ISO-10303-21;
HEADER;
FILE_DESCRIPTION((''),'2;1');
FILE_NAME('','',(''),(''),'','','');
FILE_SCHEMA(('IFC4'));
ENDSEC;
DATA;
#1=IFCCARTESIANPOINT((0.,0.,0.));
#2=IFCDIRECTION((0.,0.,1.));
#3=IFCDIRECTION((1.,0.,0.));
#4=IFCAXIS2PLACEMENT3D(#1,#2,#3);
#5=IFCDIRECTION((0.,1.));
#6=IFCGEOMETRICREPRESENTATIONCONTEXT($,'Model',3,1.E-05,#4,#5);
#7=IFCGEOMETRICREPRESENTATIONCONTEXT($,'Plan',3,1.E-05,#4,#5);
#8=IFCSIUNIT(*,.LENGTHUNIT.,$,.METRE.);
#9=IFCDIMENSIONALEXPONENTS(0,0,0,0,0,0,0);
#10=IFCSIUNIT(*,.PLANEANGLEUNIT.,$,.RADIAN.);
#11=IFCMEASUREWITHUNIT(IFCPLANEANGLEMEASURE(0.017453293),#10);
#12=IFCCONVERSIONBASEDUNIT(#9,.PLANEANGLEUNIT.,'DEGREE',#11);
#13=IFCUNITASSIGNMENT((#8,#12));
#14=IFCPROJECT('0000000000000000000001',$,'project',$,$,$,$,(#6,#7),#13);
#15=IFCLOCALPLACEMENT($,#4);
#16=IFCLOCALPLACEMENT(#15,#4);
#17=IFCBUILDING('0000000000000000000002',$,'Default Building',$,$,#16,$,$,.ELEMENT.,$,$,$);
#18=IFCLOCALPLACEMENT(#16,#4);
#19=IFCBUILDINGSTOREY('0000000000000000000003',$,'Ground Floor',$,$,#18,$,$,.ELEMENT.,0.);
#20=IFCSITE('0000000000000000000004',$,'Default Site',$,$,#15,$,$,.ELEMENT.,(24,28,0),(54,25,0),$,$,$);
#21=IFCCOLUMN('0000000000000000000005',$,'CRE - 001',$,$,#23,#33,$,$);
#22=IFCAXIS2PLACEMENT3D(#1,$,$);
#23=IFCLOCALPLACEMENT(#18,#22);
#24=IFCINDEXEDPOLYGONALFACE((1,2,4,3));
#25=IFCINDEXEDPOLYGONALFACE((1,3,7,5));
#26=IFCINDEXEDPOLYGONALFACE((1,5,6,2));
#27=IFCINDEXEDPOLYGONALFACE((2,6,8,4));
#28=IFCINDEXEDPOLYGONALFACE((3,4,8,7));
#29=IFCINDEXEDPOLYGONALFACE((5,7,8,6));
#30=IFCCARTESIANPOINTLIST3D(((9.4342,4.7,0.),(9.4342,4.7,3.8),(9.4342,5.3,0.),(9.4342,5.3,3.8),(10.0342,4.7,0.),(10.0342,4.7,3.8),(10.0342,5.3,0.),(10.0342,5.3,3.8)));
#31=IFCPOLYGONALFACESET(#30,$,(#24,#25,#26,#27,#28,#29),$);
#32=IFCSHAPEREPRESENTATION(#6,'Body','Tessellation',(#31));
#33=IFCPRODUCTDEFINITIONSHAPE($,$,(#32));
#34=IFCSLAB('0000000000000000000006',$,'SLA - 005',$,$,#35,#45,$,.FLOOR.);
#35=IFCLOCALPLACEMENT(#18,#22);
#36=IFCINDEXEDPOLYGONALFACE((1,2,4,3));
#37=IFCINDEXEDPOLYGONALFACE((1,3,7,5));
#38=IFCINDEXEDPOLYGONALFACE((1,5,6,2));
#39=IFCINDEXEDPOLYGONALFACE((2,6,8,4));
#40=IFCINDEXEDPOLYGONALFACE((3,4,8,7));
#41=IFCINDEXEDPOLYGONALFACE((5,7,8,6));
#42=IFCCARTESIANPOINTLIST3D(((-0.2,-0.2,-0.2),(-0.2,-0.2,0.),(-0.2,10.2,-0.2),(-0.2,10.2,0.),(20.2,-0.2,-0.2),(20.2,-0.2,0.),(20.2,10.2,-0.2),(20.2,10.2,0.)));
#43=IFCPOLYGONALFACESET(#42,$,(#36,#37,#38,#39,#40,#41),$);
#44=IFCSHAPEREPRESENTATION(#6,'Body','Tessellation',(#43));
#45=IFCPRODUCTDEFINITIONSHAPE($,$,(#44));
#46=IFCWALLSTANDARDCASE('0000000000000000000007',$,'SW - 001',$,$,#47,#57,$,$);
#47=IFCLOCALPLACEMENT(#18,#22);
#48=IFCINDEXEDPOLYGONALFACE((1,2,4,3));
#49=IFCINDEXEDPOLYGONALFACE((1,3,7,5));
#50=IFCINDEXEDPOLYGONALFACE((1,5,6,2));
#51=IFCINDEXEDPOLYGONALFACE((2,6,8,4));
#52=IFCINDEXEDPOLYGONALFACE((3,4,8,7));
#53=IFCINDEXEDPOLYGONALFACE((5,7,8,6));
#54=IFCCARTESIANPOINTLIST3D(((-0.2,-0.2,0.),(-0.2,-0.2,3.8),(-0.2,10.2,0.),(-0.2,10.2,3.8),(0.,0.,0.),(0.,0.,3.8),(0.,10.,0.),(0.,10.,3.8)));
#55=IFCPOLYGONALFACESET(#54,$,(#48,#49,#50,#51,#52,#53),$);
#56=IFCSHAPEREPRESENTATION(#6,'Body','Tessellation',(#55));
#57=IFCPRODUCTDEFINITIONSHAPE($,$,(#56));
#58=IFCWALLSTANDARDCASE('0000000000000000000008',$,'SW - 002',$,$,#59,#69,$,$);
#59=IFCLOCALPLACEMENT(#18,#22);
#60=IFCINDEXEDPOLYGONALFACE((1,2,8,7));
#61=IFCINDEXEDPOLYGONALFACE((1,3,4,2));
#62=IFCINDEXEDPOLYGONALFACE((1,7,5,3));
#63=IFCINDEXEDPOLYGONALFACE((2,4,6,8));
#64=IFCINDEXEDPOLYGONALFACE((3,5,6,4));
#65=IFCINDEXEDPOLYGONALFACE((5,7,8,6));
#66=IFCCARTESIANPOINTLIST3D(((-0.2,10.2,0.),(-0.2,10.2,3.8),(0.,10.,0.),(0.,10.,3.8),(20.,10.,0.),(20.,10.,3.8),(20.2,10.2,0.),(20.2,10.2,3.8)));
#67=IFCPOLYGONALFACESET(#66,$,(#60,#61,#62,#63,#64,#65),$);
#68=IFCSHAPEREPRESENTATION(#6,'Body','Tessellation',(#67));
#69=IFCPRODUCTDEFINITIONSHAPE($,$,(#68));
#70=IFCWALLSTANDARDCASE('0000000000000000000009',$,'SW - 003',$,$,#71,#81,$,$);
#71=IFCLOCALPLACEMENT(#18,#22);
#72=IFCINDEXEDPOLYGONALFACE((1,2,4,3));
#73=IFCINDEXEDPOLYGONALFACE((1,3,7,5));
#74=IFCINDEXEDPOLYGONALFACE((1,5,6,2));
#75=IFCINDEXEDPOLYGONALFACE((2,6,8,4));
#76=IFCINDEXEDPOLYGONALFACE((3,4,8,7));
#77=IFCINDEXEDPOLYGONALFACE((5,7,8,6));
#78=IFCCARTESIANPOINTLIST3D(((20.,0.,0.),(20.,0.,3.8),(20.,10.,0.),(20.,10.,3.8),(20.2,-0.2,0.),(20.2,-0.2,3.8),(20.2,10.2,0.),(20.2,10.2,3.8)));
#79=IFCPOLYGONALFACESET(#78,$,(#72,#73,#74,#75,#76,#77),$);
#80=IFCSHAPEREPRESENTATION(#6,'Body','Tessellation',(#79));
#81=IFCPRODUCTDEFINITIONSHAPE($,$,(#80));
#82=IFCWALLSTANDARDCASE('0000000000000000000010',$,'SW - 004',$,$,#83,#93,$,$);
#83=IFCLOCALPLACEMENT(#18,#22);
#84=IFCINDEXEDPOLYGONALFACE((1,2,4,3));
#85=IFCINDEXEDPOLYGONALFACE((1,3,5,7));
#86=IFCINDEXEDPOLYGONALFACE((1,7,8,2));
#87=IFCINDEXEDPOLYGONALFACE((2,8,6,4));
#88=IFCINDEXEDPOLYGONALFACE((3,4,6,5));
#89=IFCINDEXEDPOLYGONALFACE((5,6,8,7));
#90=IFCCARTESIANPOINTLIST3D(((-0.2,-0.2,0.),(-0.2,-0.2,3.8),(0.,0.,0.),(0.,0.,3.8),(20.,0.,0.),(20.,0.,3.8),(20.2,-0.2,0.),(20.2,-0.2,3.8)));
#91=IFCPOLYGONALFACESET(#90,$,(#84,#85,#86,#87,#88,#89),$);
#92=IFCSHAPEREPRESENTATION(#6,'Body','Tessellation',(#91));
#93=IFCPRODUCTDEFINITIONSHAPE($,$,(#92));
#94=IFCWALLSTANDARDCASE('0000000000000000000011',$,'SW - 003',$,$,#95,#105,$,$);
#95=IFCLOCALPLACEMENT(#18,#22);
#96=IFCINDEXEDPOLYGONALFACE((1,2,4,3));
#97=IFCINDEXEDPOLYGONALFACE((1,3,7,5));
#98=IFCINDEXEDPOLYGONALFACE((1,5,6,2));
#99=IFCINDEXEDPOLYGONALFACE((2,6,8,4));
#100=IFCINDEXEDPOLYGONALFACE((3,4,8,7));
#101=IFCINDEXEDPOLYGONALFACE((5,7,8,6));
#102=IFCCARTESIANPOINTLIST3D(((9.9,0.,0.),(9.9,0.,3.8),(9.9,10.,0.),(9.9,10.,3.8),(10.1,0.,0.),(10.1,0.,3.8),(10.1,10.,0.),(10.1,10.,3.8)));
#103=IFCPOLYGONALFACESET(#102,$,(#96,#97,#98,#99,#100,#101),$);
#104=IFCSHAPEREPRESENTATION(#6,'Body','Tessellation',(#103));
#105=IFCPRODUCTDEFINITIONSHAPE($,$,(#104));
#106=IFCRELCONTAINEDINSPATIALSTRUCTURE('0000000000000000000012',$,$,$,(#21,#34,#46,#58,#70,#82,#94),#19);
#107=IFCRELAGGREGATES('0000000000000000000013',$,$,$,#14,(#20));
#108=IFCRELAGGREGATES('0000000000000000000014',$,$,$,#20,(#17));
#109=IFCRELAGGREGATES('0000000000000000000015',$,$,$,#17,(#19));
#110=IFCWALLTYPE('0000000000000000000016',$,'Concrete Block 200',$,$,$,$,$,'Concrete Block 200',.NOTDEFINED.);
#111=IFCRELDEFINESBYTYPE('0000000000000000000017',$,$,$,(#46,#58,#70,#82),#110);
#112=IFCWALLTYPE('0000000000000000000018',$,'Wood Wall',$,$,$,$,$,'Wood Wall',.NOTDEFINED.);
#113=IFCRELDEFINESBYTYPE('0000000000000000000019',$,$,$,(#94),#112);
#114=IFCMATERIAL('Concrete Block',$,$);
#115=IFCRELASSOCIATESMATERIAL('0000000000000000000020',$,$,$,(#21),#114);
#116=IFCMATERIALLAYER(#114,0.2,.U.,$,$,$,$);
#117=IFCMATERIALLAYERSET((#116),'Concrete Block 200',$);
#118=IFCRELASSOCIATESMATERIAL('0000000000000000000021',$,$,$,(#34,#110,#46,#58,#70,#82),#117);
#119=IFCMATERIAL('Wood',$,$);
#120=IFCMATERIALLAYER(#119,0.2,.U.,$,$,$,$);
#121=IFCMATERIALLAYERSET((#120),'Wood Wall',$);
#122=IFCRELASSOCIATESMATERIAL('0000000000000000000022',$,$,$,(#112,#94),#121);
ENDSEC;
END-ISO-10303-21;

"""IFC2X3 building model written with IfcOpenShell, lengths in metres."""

from ifc_helpers import new_model, entity, si_unit, converted_unit, direction, frame, origin_with_axes, origin_2d_with_axis, place, context, project, spatial, polyline, rectangle, outline, extrude, material, layer, layer_set, layer_usage, type_object, element, save


model = new_model("IFC2X3")

# Units and contexts
model_context = context("Model", 3, precision=1e-05, world=origin_with_axes(), true_north=direction((0.0, 1.0)))
plan_context = context("Plan", 3, precision=1e-05, world=origin_with_axes(), true_north=direction((0.0, 1.0)))
ifc_project = project(units=[si_unit("LENGTHUNIT", "METRE"), converted_unit("PLANEANGLEUNIT", "DEGREE", entity("IfcPlaneAngleMeasure", 0.017453293), si_unit("PLANEANGLEUNIT", "RADIAN"), dimensions=[0, 0, 0, 0, 0, 0, 0])], contexts=[model_context, plan_context])

# Site, building, storey
site_placement = place(None, origin_with_axes())
site = spatial("IfcSite", under=ifc_project, at=site_placement, Name="Default Site", CompositionType="ELEMENT", RefLatitude=(24, 28, 0), RefLongitude=(54, 25, 0))
building_placement = place(site_placement, origin_with_axes())
building = spatial("IfcBuilding", under=site, at=building_placement, Name="Default Building", CompositionType="ELEMENT")
storey_placement = place(building_placement, origin_with_axes())
storey = spatial("IfcBuildingStorey", under=building, at=storey_placement, Name="Ground Floor", CompositionType="ELEMENT", Elevation=0.0)

# Column
ifc_material_1 = material(Name="Concrete Block")
column_placement = place(storey_placement, frame((9.7342, 5.0, 0.0), z_axis=(0.0, 0.0, 1.0), x_axis=(1.0, 0.0, 0.0)))
element("IfcColumn", 1, at=column_placement, inside=storey, material=ifc_material_1, Name="CRE - 001", context=model_context, shape_type="SweptSolid", body=[
    extrude(rectangle(XDim=0.6, YDim=0.6, at=origin_2d_with_axis()), origin_with_axes(), (0.0, 0.0, 1.0), 3.8),
])

# Slab
ifc_layer_1 = layer(ifc_material_1, 0.2, ventilated="UNKNOWN")
ifc_layer_set_1 = layer_set([ifc_layer_1], Name="Concrete Block 200")
ifc_layer_usage_1 = layer_usage(ifc_layer_set_1, "AXIS3", "NEGATIVE", 0.2)
slab_placement = place(storey_placement, frame((-0.2, 10.2, -0.2), z_axis=(0.0, 0.0, 1.0), x_axis=(1.0, 0.0, 0.0)))
element("IfcSlab", 2, at=slab_placement, inside=storey, material=ifc_layer_usage_1, Name="SLA - 005", PredefinedType="FLOOR", context=model_context, shape_type="SweptSolid", body=[
    extrude(outline(polyline([(0.0, 0.0), (20.4, 0.0), (20.4, -10.4), (0.0, -10.4), (0.0, 0.0)])), origin_with_axes(), (0.0, 0.0, 1.0), 0.2),
])

# Walls
ifc_layer_usage_2 = layer_usage(ifc_layer_set_1, "AXIS2", "POSITIVE", 0.0)
wall_type_1 = type_object("IfcWallType", Name="Concrete Block 200", ElementType="Concrete Block 200", PredefinedType="NOTDEFINED", material=ifc_layer_set_1)
wall_1_placement = place(storey_placement, frame((0.0, 0.0, 0.0), z_axis=(0.0, 0.0, 1.0), x_axis=(0.0, 1.0, 0.0)))
element("IfcWallStandardCase", 3, at=wall_1_placement, inside=storey, type_object=wall_type_1, material=ifc_layer_usage_2, Name="SW - 001", context=model_context, shape_type="SweptSolid", body=[
    extrude(outline(polyline([(0.0, 0.0), (10.0, 0.0), (10.2, 0.2), (-0.2, 0.2), (0.0, 0.0)])), origin_with_axes(), (0.0, 0.0, 1.0), 3.8),
])
ifc_layer_usage_3 = layer_usage(ifc_layer_set_1, "AXIS2", "POSITIVE", 0.0)
wall_2_placement = place(storey_placement, frame((0.0, 10.0, 0.0), z_axis=(0.0, 0.0, 1.0), x_axis=(1.0, 0.0, 0.0)))
element("IfcWallStandardCase", 4, at=wall_2_placement, inside=storey, type_object=wall_type_1, material=ifc_layer_usage_3, Name="SW - 002", context=model_context, shape_type="SweptSolid", body=[
    extrude(outline(polyline([(0.0, 0.0), (20.0, 0.0), (20.2, 0.2), (-0.2, 0.2), (0.0, 0.0)])), origin_with_axes(), (0.0, 0.0, 1.0), 3.8),
])
ifc_layer_usage_4 = layer_usage(ifc_layer_set_1, "AXIS2", "POSITIVE", 0.0)
wall_3_placement = place(storey_placement, frame((20.0, 10.0, 0.0), z_axis=(0.0, 0.0, 1.0), x_axis=(0.0, -1.0, 0.0)))
element("IfcWallStandardCase", 5, at=wall_3_placement, inside=storey, type_object=wall_type_1, material=ifc_layer_usage_4, Name="SW - 003", context=model_context, shape_type="SweptSolid", body=[
    extrude(outline(polyline([(0.0, 0.0), (10.0, 0.0), (10.2, 0.2), (-0.2, 0.2), (0.0, 0.0)])), origin_with_axes(), (0.0, 0.0, 1.0), 3.8),
])
ifc_layer_usage_5 = layer_usage(ifc_layer_set_1, "AXIS2", "POSITIVE", 0.0)
wall_4_placement = place(storey_placement, frame((20.0, 0.0, 0.0), z_axis=(0.0, 0.0, 1.0), x_axis=(-1.0, 0.0, 0.0)))
element("IfcWallStandardCase", 6, at=wall_4_placement, inside=storey, type_object=wall_type_1, material=ifc_layer_usage_5, Name="SW - 004", context=model_context, shape_type="SweptSolid", body=[
    extrude(outline(polyline([(0.0, 0.0), (20.0, 0.0), (20.2, 0.2), (-0.2, 0.2), (0.0, 0.0)])), origin_with_axes(), (0.0, 0.0, 1.0), 3.8),
])
ifc_material_2 = material(Name="Wood")
ifc_layer_2 = layer(ifc_material_2, 0.2, ventilated="UNKNOWN")
ifc_layer_set_2 = layer_set([ifc_layer_2], Name="Wood Wall")
ifc_layer_usage_6 = layer_usage(ifc_layer_set_2, "AXIS2", "NEGATIVE", 0.0)
wall_type_2 = type_object("IfcWallType", Name="Wood Wall", ElementType="Wood Wall", PredefinedType="NOTDEFINED", material=ifc_layer_set_2)
wall_5_placement = place(storey_placement, frame((10.1, 10.0, 0.0), z_axis=(0.0, 0.0, 1.0), x_axis=(0.0, -1.0, 0.0)))
element("IfcWallStandardCase", 7, at=wall_5_placement, inside=storey, type_object=wall_type_2, material=ifc_layer_usage_6, Name="SW - 003", context=model_context, shape_type="SweptSolid", body=[
    extrude(outline(polyline([(0.0, -0.2), (10.0, -0.2), (10.0, 0.0), (0.0, 0.0), (0.0, -0.2)])), origin_with_axes(), (0.0, 0.0, 1.0), 3.8),
])

save(model, "model.ifc")
